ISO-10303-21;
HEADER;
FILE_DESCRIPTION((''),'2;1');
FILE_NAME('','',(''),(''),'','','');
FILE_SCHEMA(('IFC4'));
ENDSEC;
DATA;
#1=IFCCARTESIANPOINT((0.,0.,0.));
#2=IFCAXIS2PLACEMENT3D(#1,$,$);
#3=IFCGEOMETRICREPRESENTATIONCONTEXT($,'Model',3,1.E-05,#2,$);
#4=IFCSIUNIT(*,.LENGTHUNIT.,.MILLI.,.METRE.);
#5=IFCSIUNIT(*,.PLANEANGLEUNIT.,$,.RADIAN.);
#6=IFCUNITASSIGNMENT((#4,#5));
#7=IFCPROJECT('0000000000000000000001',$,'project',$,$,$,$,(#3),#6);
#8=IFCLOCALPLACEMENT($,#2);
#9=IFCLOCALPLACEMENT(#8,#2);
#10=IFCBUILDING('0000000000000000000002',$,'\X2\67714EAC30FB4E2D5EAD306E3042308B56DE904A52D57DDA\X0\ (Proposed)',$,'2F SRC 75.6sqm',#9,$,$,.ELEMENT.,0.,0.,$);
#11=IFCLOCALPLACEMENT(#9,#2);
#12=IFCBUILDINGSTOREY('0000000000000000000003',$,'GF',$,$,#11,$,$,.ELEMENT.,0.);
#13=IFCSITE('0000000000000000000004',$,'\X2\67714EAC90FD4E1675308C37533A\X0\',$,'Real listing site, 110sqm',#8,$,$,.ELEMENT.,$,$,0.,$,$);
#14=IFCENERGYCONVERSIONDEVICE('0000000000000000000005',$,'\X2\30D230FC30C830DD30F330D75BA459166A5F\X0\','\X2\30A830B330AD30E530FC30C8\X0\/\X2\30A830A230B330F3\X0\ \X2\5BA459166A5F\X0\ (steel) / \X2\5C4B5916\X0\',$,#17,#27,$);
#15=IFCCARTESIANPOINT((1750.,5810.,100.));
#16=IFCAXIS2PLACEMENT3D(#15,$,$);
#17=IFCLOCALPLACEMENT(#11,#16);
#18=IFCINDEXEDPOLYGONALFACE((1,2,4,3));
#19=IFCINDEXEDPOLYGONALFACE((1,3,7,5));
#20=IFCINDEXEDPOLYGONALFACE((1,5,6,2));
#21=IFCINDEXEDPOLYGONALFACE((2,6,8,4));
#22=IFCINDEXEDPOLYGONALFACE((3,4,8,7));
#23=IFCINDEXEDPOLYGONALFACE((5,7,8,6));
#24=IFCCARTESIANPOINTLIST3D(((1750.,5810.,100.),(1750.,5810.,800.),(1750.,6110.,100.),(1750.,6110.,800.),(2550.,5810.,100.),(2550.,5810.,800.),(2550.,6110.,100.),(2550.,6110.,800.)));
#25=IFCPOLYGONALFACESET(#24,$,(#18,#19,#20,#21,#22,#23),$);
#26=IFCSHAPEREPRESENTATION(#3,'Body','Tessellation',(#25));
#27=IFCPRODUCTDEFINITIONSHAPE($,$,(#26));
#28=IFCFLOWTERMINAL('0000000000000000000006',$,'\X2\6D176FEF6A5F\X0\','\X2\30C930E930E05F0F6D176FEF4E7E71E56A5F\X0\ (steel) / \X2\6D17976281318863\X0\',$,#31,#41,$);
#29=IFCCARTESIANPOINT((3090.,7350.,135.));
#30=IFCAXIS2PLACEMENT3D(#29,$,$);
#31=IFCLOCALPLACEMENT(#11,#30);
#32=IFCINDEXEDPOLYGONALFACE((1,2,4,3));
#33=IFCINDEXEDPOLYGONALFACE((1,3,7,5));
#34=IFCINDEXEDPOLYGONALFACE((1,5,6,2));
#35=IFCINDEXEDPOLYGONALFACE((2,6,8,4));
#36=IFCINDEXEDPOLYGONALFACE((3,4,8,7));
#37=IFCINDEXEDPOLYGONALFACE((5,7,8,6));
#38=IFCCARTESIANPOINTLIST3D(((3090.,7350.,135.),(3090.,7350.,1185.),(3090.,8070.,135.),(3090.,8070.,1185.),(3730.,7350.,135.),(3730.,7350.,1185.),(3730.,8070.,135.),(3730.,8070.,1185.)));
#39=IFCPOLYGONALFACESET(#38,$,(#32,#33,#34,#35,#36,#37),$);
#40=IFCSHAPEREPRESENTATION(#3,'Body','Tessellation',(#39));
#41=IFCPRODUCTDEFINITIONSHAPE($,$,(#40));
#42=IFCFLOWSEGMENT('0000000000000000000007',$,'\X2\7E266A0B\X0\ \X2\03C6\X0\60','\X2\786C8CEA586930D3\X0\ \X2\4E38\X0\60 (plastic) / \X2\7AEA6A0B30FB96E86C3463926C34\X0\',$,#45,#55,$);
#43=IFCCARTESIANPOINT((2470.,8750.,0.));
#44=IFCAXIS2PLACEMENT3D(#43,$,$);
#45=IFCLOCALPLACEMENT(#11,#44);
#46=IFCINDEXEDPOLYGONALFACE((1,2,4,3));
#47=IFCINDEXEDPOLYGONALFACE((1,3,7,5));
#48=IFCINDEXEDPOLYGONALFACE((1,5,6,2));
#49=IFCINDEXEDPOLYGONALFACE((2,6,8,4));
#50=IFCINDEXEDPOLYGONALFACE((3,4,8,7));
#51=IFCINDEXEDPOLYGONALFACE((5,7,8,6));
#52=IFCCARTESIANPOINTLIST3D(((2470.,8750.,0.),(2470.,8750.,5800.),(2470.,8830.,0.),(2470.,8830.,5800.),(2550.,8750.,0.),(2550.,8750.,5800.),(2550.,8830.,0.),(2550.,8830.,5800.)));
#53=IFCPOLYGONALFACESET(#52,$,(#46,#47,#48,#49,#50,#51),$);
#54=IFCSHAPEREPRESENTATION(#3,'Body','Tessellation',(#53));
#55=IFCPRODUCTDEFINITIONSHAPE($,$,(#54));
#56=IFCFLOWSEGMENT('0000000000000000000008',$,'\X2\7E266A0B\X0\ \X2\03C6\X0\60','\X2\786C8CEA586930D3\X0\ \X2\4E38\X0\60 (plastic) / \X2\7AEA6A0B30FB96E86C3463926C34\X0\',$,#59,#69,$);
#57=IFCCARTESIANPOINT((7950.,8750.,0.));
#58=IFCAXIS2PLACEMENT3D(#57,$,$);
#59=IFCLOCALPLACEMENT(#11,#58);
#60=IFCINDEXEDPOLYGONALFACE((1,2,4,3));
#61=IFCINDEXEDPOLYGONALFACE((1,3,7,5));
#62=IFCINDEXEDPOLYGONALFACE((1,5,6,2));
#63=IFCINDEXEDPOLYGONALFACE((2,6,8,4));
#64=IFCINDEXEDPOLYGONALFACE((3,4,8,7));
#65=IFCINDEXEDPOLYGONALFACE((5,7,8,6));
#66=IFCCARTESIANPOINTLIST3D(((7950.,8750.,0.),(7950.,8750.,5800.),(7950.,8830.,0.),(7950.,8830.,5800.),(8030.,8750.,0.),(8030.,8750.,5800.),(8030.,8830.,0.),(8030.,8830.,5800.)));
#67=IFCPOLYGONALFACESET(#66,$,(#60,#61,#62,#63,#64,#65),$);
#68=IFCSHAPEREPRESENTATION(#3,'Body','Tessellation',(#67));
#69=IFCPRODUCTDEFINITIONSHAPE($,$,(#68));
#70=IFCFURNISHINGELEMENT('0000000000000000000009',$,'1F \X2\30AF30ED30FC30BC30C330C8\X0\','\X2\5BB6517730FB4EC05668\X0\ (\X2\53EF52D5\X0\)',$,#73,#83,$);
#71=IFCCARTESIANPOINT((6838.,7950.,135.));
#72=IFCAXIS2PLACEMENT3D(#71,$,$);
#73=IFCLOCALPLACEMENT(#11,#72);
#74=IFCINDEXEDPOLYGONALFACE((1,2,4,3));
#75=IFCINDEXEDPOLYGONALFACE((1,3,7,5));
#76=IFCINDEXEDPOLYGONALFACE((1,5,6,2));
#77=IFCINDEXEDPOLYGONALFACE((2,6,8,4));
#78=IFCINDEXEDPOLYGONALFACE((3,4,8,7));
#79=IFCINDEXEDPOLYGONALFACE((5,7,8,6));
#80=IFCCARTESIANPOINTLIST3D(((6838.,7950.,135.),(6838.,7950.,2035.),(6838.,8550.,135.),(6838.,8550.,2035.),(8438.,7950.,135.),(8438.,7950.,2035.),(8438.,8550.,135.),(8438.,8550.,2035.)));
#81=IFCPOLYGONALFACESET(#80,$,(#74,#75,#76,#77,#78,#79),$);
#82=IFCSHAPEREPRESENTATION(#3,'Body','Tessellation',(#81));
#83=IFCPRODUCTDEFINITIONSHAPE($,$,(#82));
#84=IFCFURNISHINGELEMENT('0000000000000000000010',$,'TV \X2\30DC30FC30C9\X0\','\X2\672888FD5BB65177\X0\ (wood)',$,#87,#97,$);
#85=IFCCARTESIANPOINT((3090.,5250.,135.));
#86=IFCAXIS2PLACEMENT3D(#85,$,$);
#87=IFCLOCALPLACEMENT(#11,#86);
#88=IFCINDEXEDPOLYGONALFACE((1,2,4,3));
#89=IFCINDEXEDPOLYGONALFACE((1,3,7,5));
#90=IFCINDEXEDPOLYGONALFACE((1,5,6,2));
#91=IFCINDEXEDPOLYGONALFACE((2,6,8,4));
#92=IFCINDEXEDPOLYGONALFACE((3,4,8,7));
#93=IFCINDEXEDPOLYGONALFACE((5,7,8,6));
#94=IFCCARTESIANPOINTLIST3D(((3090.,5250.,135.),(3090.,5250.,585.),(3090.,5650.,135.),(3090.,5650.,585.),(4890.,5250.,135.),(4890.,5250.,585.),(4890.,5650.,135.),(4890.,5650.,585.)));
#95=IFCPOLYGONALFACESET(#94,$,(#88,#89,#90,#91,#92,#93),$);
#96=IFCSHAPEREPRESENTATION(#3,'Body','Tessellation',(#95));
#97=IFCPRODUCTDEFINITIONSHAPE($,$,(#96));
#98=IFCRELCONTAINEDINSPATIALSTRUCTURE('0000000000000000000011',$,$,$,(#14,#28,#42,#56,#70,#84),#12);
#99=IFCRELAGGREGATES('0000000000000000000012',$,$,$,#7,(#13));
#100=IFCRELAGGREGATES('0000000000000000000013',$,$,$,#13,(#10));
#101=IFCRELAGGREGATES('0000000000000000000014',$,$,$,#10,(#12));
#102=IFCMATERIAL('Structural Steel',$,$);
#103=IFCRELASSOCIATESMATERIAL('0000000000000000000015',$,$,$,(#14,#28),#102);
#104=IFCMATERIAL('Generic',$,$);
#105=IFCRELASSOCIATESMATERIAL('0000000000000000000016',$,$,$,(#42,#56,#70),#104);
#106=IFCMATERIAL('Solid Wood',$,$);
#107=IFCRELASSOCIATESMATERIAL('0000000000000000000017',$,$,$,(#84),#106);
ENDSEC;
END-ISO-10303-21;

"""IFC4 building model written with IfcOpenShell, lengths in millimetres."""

from ifc_helpers import new_model, si_unit, frame, frame_2d, origin, place, context, project, spatial, rectangle, extrude, material, element, save


model = new_model("IFC4")

# Units and contexts
model_context = context("Model", 3, precision=1e-05, world=origin())
ifc_project = project(units=[si_unit("LENGTHUNIT", "METRE", prefix="MILLI"), si_unit("PLANEANGLEUNIT", "RADIAN")], contexts=[model_context])

# Site, building, storey
site_placement = place(None, origin())
site = spatial("IfcSite", under=ifc_project, at=site_placement, Name="東京都世田谷区", ObjectType="Real listing site, 110sqm", CompositionType="ELEMENT", RefElevation=0.0)
building_placement = place(site_placement, origin())
building = spatial("IfcBuilding", under=site, at=building_placement, Name="東京・中庭のある回遊動線 (Proposed)", ObjectType="2F SRC 75.6sqm", CompositionType="ELEMENT", ElevationOfRefHeight=0.0, ElevationOfTerrain=0.0)
storey_placement = place(building_placement, origin())
storey = spatial("IfcBuildingStorey", under=building, at=storey_placement, Name="GF", CompositionType="ELEMENT", Elevation=0.0)

# Shared definitions
ifc_material_1 = material(Name="Solid Wood")

# Shared definitions
ifc_material_2 = material(Name="Generic")

# Shared definitions
ifc_material_3 = material(Name="Structural Steel")

# Energy conversion device
energy_conversion_device_placement = place(storey_placement, frame((1750.0, 5810.0, 100.0)))
element("IfcEnergyConversionDevice", 1, at=energy_conversion_device_placement, inside=storey, material=ifc_material_3, Name="ヒートポンプ室外機", Description="エコキュート/エアコン 室外機 (steel) / 屋外", context=model_context, shape_type="SweptSolid", body=[
    extrude(rectangle(XDim=800.0, YDim=300.0, at=frame_2d((400.0, 150.0))), frame((1750.0, 5810.0, 100.0)), (0.0, 0.0, 1.0), 700.0),
])

# Flow terminal
flow_terminal_placement = place(storey_placement, frame((3090.0, 7350.0, 135.0)))
element("IfcFlowTerminal", 2, at=flow_terminal_placement, inside=storey, material=ifc_material_3, Name="洗濯機", Description="ドラム式洗濯乾燥機 (steel) / 洗面脱衣", context=model_context, shape_type="SweptSolid", body=[
    extrude(rectangle(XDim=640.0, YDim=720.0, at=frame_2d((320.0, 360.0))), frame((3090.0, 7350.0, 135.0)), (0.0, 0.0, 1.0), 1050.0),
])

# Flow segments
flow_segment_1_placement = place(storey_placement, frame((2470.0, 8750.0, 0.0)))
element("IfcFlowSegment", 3, at=flow_segment_1_placement, inside=storey, material=ifc_material_2, Name="縦樋 φ60", Description="硬質塩ビ 丸60 (plastic) / 竪樋・雨水排水", context=model_context, shape_type="SweptSolid", body=[
    extrude(rectangle(XDim=80.0, YDim=80.0, at=frame_2d((40.0, 40.0))), frame((2470.0, 8750.0, 0.0)), (0.0, 0.0, 1.0), 5800.0),
])
flow_segment_2_placement = place(storey_placement, frame((7950.0, 8750.0, 0.0)))
element("IfcFlowSegment", 4, at=flow_segment_2_placement, inside=storey, material=ifc_material_2, Name="縦樋 φ60", Description="硬質塩ビ 丸60 (plastic) / 竪樋・雨水排水", context=model_context, shape_type="SweptSolid", body=[
    extrude(rectangle(XDim=80.0, YDim=80.0, at=frame_2d((40.0, 40.0))), frame((7950.0, 8750.0, 0.0)), (0.0, 0.0, 1.0), 5800.0),
])

# Furnishing elements
furnishing_1_placement = place(storey_placement, frame((6838.0, 7950.0, 135.0)))
element("IfcFurnishingElement", 5, at=furnishing_1_placement, inside=storey, material=ifc_material_2, Name="1F クローゼット", Description="家具・什器 (可動)", context=model_context, shape_type="SweptSolid", body=[
    extrude(rectangle(XDim=1600.0, YDim=600.0, at=frame_2d((800.0, 300.0))), frame((6838.0, 7950.0, 135.0)), (0.0, 0.0, 1.0), 1900.0),
])
furnishing_2_placement = place(storey_placement, frame((3090.0, 5250.0, 135.0)))
element("IfcFurnishingElement", 6, at=furnishing_2_placement, inside=storey, material=ifc_material_1, Name="TV ボード", Description="木製家具 (wood)", context=model_context, shape_type="SweptSolid", body=[
    extrude(rectangle(XDim=1800.0, YDim=400.0, at=frame_2d((900.0, 200.0))), frame((3090.0, 5250.0, 135.0)), (0.0, 0.0, 1.0), 450.0),
])

save(model, "model.ifc")
